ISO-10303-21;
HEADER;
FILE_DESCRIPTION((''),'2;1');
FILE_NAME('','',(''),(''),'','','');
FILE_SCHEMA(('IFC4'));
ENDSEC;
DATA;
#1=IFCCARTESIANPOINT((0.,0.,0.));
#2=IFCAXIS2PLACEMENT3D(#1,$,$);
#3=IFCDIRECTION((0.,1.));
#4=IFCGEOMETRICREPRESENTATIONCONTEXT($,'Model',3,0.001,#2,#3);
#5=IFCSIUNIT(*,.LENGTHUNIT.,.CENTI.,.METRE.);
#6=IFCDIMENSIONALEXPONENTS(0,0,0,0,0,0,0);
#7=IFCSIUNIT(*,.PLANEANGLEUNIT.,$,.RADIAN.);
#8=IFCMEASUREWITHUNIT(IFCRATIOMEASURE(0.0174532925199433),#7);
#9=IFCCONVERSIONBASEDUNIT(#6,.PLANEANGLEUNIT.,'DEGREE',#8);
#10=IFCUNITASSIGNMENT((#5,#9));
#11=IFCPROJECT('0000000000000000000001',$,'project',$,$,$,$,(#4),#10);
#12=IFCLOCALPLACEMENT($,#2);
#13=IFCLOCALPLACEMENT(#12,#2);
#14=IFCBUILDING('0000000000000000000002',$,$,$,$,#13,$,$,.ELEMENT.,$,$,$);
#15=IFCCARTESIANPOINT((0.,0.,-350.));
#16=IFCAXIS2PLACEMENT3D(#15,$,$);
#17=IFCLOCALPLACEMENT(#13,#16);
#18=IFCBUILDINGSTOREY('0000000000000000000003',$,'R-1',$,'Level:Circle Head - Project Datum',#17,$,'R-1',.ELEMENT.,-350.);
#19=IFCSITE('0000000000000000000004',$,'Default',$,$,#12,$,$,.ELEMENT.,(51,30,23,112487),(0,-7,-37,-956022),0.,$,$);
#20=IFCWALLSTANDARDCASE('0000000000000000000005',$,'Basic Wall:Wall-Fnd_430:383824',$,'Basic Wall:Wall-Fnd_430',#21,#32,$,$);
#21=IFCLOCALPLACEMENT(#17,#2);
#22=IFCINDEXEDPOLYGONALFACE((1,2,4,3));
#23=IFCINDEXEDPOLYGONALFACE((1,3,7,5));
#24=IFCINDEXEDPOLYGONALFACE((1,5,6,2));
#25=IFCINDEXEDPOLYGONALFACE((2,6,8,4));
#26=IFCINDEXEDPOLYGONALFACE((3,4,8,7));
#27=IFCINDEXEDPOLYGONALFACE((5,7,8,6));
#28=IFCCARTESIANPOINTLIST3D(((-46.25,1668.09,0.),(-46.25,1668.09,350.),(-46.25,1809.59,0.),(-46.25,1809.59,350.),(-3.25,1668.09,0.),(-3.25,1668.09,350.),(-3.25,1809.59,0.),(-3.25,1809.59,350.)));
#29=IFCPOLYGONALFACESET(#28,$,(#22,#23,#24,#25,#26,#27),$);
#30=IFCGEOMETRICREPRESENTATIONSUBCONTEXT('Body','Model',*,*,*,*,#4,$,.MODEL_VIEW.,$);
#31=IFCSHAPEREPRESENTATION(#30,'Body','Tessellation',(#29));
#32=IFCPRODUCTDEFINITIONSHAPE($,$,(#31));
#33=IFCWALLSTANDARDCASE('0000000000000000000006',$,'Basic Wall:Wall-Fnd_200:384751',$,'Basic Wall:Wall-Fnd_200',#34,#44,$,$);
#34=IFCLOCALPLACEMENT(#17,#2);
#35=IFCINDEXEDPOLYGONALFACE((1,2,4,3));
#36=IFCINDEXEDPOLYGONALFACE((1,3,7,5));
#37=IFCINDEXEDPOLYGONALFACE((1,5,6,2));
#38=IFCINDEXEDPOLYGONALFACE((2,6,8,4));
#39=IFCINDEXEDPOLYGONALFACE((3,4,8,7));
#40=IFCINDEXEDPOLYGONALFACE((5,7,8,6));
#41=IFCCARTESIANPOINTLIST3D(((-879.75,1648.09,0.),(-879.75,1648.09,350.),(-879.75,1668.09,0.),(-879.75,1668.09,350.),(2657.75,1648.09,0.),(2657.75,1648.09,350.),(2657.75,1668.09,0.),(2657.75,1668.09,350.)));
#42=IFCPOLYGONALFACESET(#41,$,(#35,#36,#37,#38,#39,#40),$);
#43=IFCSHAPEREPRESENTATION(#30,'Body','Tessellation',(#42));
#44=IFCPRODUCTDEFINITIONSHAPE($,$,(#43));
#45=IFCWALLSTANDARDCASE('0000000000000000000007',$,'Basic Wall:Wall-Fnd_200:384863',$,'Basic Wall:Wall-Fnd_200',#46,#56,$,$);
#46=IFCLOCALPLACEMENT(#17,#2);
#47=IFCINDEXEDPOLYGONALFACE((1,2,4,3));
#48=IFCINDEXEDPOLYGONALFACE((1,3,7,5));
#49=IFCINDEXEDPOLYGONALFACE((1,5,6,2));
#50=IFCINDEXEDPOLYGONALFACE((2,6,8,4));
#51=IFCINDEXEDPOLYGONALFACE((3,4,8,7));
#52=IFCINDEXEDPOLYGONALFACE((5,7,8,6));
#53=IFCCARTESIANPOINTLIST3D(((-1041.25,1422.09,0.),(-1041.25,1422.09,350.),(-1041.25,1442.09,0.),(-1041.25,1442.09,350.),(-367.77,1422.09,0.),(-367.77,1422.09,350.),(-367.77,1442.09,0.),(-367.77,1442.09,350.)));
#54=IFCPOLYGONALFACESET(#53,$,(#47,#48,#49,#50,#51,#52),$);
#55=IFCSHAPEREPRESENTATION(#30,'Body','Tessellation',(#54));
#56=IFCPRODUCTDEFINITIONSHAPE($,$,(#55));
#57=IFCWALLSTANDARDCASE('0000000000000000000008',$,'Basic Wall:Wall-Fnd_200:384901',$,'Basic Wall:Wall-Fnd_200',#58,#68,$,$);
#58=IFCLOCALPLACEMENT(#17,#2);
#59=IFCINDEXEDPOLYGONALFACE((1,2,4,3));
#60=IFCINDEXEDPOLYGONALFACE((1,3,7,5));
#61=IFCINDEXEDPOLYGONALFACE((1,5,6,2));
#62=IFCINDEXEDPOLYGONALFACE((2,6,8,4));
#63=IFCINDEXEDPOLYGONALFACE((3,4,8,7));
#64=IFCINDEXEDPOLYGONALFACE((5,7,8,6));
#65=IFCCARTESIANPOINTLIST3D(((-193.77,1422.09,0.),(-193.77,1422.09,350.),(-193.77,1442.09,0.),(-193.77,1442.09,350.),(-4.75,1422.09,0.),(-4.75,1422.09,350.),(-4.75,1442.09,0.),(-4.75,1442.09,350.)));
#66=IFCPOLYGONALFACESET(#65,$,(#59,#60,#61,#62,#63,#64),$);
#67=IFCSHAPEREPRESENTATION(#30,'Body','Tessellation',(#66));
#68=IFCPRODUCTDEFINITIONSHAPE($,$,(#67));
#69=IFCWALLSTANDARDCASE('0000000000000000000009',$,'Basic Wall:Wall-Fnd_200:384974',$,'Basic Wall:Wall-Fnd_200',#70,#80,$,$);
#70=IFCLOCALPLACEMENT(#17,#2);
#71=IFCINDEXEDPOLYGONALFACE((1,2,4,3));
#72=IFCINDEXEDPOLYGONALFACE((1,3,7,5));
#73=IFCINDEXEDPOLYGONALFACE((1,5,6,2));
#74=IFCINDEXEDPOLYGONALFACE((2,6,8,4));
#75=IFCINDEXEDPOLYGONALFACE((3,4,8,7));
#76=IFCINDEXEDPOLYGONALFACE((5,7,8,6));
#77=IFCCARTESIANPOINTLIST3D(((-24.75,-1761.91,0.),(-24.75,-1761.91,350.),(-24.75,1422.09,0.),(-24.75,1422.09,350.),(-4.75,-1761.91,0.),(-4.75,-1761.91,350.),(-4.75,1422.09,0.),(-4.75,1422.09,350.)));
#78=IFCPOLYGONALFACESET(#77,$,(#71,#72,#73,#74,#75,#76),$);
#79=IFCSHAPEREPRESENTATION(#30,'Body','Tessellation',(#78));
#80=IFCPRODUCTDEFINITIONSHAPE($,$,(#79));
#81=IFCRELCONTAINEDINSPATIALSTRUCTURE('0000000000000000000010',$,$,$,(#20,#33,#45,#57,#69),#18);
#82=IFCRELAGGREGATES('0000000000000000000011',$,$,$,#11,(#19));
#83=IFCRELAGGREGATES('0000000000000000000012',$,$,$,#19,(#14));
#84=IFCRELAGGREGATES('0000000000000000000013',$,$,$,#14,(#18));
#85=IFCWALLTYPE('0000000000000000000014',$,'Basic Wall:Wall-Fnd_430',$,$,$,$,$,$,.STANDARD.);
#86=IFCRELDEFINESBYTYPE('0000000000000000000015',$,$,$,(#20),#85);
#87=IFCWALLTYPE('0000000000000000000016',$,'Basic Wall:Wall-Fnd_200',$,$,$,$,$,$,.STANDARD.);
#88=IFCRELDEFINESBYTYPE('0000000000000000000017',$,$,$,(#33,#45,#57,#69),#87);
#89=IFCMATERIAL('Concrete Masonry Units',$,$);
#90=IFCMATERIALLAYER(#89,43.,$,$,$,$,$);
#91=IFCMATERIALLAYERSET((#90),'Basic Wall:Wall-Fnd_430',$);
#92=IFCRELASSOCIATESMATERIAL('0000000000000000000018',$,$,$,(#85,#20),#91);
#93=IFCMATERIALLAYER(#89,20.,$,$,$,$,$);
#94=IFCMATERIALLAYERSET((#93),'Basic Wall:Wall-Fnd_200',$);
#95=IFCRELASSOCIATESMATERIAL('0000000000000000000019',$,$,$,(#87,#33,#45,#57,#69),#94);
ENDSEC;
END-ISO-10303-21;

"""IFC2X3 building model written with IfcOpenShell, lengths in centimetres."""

from ifc_helpers import new_model, entity, si_unit, converted_unit, direction, frame, frame_2d, origin, place, context, subcontext, project, spatial, rectangle, extrude, material, layer, layer_set, layer_usage, type_object, element, save


model = new_model("IFC2X3")

# Units and contexts
model_context = context("Model", 3, precision=0.001, world=origin(), true_north=direction((0.0, 1.0)))
body_context = subcontext(model_context, "Body", "Model", "MODEL_VIEW")
ifc_project = project(units=[si_unit("LENGTHUNIT", "METRE", prefix="CENTI"), converted_unit("PLANEANGLEUNIT", "DEGREE", entity("IfcRatioMeasure", 0.0174532925199433), si_unit("PLANEANGLEUNIT", "RADIAN"), dimensions=[0, 0, 0, 0, 0, 0, 0])], contexts=[model_context])

# Site, building, storey
site_placement = place(None, origin())
site = spatial("IfcSite", under=ifc_project, at=site_placement, Name="Default", CompositionType="ELEMENT", RefLatitude=(51, 30, 23, 112487), RefLongitude=(0, -7, -37, -956022), RefElevation=0.0)
building_placement = place(site_placement, origin())
building = spatial("IfcBuilding", under=site, at=building_placement, CompositionType="ELEMENT")
storey_placement = place(building_placement, frame((0.0, 0.0, -350.0)))
storey = spatial("IfcBuildingStorey", under=building, at=storey_placement, Name="R-1", ObjectType="Level:Circle Head - Project Datum", LongName="R-1", CompositionType="ELEMENT", Elevation=-350.0)

# Walls
ifc_material_1 = material(Name="Concrete Masonry Units")
ifc_layer_1 = layer(ifc_material_1, 43.0)
ifc_layer_set_1 = layer_set([ifc_layer_1], Name="Basic Wall:Wall-Fnd_430")
wall_type_1 = type_object("IfcWallType", Name="Basic Wall:Wall-Fnd_430", PredefinedType="STANDARD", material=ifc_layer_set_1)
ifc_layer_usage_1 = layer_usage(ifc_layer_set_1, "AXIS2", "NEGATIVE", 21.5)
wall_1_placement = place(storey_placement, frame((-24.75, 1809.59, 0.0), z_axis=(0.0, 0.0, 1.0), x_axis=(0.0, -1.0, 0.0)))
element("IfcWallStandardCase", 1, at=wall_1_placement, inside=storey, type_object=wall_type_1, material=ifc_layer_usage_1, Name="Basic Wall:Wall-Fnd_430:383824", ObjectType="Basic Wall:Wall-Fnd_430", context=body_context, shape_type="SweptSolid", body=[
    extrude(rectangle(XDim=141.5, YDim=43.0, at=frame_2d((70.75, 0.0), x_axis=(-1.0, 0.0))), origin(), (0.0, 0.0, 1.0), 350.0),
])
ifc_layer_2 = layer(ifc_material_1, 20.0)
ifc_layer_set_2 = layer_set([ifc_layer_2], Name="Basic Wall:Wall-Fnd_200")
ifc_layer_usage_2 = layer_usage(ifc_layer_set_2, "AXIS2", "POSITIVE", -10.0)
wall_type_2 = type_object("IfcWallType", Name="Basic Wall:Wall-Fnd_200", PredefinedType="STANDARD", material=ifc_layer_set_2)
wall_2_placement = place(storey_placement, frame((-879.75, 1658.09, 0.0)))
element("IfcWallStandardCase", 2, at=wall_2_placement, inside=storey, type_object=wall_type_2, material=ifc_layer_usage_2, Name="Basic Wall:Wall-Fnd_200:384751", ObjectType="Basic Wall:Wall-Fnd_200", context=body_context, shape_type="SweptSolid", body=[
    extrude(rectangle(XDim=3537.5, YDim=20.0, at=frame_2d((1768.75, 0.0), x_axis=(-1.0, 0.0))), origin(), (0.0, 0.0, 1.0), 350.0),
])
ifc_layer_usage_3 = layer_usage(ifc_layer_set_2, "AXIS2", "POSITIVE", -10.0)
wall_3_placement = place(storey_placement, frame((-1041.25, 1432.09, 0.0)))
element("IfcWallStandardCase", 3, at=wall_3_placement, inside=storey, type_object=wall_type_2, material=ifc_layer_usage_3, Name="Basic Wall:Wall-Fnd_200:384863", ObjectType="Basic Wall:Wall-Fnd_200", context=body_context, shape_type="SweptSolid", body=[
    extrude(rectangle(XDim=673.48, YDim=20.0, at=frame_2d((336.74, 0.0), x_axis=(-1.0, 0.0))), origin(), (0.0, 0.0, 1.0), 350.0),
])
ifc_layer_usage_4 = layer_usage(ifc_layer_set_2, "AXIS2", "POSITIVE", -10.0)
wall_4_placement = place(storey_placement, frame((-193.77, 1432.09, 0.0)))
element("IfcWallStandardCase", 4, at=wall_4_placement, inside=storey, type_object=wall_type_2, material=ifc_layer_usage_4, Name="Basic Wall:Wall-Fnd_200:384901", ObjectType="Basic Wall:Wall-Fnd_200", context=body_context, shape_type="SweptSolid", body=[
    extrude(rectangle(XDim=189.02, YDim=20.0, at=frame_2d((94.51, 0.0), x_axis=(-1.0, 0.0))), origin(), (0.0, 0.0, 1.0), 350.0),
])
ifc_layer_usage_5 = layer_usage(ifc_layer_set_2, "AXIS2", "POSITIVE", -10.0)
wall_5_placement = place(storey_placement, frame((-14.75, 1422.09, 0.0), z_axis=(0.0, 0.0, 1.0), x_axis=(0.0, -1.0, 0.0)))
element("IfcWallStandardCase", 5, at=wall_5_placement, inside=storey, type_object=wall_type_2, material=ifc_layer_usage_5, Name="Basic Wall:Wall-Fnd_200:384974", ObjectType="Basic Wall:Wall-Fnd_200", context=body_context, shape_type="SweptSolid", body=[
    extrude(rectangle(XDim=3184.0, YDim=20.0, at=frame_2d((1592.0, 0.0), x_axis=(-1.0, 0.0))), origin(), (0.0, 0.0, 1.0), 350.0),
])

save(model, "model.ifc")
